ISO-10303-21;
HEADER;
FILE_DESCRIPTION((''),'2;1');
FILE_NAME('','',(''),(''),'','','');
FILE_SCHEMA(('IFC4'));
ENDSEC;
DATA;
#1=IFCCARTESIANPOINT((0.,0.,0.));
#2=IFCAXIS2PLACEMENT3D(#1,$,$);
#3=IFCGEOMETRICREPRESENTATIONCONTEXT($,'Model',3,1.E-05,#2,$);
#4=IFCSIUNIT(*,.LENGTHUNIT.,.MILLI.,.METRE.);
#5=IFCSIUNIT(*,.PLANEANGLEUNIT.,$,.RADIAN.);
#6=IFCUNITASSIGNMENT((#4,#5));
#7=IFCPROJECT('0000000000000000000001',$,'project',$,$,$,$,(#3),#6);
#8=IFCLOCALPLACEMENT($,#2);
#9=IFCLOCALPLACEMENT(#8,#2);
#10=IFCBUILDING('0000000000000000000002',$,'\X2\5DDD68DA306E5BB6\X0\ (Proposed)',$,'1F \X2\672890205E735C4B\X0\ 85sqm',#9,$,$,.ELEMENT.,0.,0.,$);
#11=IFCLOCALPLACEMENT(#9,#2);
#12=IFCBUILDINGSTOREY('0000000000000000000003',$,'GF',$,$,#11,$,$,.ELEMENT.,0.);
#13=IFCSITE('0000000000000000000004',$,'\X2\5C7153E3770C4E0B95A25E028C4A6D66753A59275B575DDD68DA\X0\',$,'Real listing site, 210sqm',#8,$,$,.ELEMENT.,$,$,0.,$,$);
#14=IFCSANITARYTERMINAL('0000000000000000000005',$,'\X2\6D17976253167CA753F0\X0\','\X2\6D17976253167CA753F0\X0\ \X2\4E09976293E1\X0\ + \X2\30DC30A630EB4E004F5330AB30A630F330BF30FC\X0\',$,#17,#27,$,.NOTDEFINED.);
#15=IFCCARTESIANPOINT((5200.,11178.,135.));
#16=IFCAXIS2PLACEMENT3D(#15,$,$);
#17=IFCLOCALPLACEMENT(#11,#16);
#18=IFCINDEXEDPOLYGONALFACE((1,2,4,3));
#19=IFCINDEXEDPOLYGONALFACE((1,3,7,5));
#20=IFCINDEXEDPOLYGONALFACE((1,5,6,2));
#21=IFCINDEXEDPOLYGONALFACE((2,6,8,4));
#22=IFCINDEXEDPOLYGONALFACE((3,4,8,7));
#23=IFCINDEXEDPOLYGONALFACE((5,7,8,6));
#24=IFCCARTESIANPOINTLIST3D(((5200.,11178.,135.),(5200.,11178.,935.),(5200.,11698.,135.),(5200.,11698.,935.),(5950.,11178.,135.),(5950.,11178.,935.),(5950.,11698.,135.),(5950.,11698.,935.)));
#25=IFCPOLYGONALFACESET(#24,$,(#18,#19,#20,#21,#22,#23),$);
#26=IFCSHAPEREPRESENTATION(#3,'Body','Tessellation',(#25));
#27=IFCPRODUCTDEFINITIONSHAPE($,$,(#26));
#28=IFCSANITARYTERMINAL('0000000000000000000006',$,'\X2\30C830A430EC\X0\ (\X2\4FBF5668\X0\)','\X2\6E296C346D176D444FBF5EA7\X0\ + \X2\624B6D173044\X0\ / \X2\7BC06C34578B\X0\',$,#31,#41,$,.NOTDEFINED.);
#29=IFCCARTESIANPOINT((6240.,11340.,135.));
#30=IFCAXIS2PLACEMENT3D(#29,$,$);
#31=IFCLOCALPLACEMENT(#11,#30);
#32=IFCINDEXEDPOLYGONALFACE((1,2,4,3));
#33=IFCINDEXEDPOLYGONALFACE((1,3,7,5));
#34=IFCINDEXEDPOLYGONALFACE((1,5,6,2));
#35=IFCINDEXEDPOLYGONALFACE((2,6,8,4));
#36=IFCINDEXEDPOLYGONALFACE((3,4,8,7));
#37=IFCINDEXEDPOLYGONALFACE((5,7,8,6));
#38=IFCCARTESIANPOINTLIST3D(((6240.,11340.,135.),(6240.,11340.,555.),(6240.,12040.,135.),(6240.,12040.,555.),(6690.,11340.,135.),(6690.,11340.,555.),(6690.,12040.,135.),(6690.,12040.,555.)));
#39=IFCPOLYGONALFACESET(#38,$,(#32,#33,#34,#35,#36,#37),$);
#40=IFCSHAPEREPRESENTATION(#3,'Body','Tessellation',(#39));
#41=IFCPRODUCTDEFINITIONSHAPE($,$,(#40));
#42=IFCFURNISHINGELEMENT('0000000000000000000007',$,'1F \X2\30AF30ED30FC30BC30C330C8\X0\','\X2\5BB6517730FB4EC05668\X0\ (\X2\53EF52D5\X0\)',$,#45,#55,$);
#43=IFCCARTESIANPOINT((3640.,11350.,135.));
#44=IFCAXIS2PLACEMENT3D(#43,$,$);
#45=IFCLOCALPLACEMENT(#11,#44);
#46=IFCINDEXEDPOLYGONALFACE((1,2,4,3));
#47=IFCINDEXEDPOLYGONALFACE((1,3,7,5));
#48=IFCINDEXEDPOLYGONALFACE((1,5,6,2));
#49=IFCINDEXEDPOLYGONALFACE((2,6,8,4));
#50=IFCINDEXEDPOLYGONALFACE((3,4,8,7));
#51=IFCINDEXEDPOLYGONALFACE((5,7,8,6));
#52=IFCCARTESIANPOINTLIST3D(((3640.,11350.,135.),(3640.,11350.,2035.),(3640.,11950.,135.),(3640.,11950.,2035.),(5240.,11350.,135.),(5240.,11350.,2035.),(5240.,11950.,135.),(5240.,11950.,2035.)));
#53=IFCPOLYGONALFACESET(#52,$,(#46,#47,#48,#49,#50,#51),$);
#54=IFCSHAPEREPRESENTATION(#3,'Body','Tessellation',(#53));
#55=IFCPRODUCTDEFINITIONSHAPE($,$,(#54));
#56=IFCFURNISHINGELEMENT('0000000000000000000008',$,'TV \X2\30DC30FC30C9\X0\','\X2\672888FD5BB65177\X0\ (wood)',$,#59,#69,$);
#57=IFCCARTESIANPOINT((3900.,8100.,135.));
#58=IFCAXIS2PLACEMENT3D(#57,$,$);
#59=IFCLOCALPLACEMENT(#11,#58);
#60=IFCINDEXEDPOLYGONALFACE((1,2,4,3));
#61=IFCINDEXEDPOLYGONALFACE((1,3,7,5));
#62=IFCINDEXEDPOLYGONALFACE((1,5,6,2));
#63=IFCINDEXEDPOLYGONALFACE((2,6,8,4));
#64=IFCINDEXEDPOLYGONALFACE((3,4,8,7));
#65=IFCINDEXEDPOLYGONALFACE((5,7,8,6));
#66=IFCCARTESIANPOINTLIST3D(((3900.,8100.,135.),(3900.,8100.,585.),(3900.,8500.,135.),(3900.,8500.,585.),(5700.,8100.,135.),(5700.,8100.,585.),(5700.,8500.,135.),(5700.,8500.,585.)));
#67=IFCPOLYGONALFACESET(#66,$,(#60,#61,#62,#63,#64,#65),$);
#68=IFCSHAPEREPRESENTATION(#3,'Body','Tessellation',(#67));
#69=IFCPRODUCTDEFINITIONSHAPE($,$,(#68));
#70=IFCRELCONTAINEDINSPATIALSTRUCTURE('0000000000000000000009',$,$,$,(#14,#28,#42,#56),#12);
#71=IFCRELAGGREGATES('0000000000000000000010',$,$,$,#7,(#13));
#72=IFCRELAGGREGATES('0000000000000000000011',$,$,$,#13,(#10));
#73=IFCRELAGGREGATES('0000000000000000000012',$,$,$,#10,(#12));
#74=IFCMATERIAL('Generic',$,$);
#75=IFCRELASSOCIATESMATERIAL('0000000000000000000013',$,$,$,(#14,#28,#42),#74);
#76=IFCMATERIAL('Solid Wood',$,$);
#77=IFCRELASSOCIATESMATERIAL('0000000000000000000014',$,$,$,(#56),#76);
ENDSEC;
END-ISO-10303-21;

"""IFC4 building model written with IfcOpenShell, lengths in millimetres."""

from ifc_helpers import new_model, si_unit, frame, frame_2d, origin, place, context, project, spatial, rectangle, extrude, material, element, save


model = new_model("IFC4")

# Units and contexts
model_context = context("Model", 3, precision=1e-05, world=origin())
ifc_project = project(units=[si_unit("LENGTHUNIT", "METRE", prefix="MILLI"), si_unit("PLANEANGLEUNIT", "RADIAN")], contexts=[model_context])

# Site, building, storey
site_placement = place(None, origin())
site = spatial("IfcSite", under=ifc_project, at=site_placement, Name="山口県下関市豊浦町大字川棚", ObjectType="Real listing site, 210sqm", CompositionType="ELEMENT", RefElevation=0.0)
building_placement = place(site_placement, origin())
building = spatial("IfcBuilding", under=site, at=building_placement, Name="川棚の家 (Proposed)", ObjectType="1F 木造平屋 85sqm", CompositionType="ELEMENT", ElevationOfRefHeight=0.0, ElevationOfTerrain=0.0)
storey_placement = place(building_placement, origin())
storey = spatial("IfcBuildingStorey", under=building, at=storey_placement, Name="GF", CompositionType="ELEMENT", Elevation=0.0)

# Shared definitions
ifc_material_1 = material(Name="Solid Wood")

# Shared definitions
ifc_material_2 = material(Name="Generic")

# Sanitary terminals
sanitary_terminal_1_placement = place(storey_placement, frame((5200.0, 11178.0, 135.0)))
element("IfcSanitaryTerminal", 1, at=sanitary_terminal_1_placement, inside=storey, material=ifc_material_2, Name="洗面化粧台", Description="洗面化粧台 三面鏡 + ボウル一体カウンター", PredefinedType="NOTDEFINED", context=model_context, shape_type="SweptSolid", body=[
    extrude(rectangle(XDim=750.0, YDim=520.0, at=frame_2d((375.0, 260.0))), frame((5200.0, 11178.0, 135.0)), (0.0, 0.0, 1.0), 800.0),
])
sanitary_terminal_2_placement = place(storey_placement, frame((6240.0, 11340.0, 135.0)))
element("IfcSanitaryTerminal", 2, at=sanitary_terminal_2_placement, inside=storey, material=ifc_material_2, Name="トイレ (便器)", Description="温水洗浄便座 + 手洗い / 節水型", PredefinedType="NOTDEFINED", context=model_context, shape_type="SweptSolid", body=[
    extrude(rectangle(XDim=450.0, YDim=700.0, at=frame_2d((225.0, 350.0))), frame((6240.0, 11340.0, 135.0)), (0.0, 0.0, 1.0), 420.0),
])

# Furnishing elements
furnishing_1_placement = place(storey_placement, frame((3640.0, 11350.0, 135.0)))
element("IfcFurnishingElement", 3, at=furnishing_1_placement, inside=storey, material=ifc_material_2, Name="1F クローゼット", Description="家具・什器 (可動)", context=model_context, shape_type="SweptSolid", body=[
    extrude(rectangle(XDim=1600.0, YDim=600.0, at=frame_2d((800.0, 300.0))), frame((3640.0, 11350.0, 135.0)), (0.0, 0.0, 1.0), 1900.0),
])
furnishing_2_placement = place(storey_placement, frame((3900.0, 8100.0, 135.0)))
element("IfcFurnishingElement", 4, at=furnishing_2_placement, inside=storey, material=ifc_material_1, Name="TV ボード", Description="木製家具 (wood)", context=model_context, shape_type="SweptSolid", body=[
    extrude(rectangle(XDim=1800.0, YDim=400.0, at=frame_2d((900.0, 200.0))), frame((3900.0, 8100.0, 135.0)), (0.0, 0.0, 1.0), 450.0),
])

save(model, "model.ifc")
